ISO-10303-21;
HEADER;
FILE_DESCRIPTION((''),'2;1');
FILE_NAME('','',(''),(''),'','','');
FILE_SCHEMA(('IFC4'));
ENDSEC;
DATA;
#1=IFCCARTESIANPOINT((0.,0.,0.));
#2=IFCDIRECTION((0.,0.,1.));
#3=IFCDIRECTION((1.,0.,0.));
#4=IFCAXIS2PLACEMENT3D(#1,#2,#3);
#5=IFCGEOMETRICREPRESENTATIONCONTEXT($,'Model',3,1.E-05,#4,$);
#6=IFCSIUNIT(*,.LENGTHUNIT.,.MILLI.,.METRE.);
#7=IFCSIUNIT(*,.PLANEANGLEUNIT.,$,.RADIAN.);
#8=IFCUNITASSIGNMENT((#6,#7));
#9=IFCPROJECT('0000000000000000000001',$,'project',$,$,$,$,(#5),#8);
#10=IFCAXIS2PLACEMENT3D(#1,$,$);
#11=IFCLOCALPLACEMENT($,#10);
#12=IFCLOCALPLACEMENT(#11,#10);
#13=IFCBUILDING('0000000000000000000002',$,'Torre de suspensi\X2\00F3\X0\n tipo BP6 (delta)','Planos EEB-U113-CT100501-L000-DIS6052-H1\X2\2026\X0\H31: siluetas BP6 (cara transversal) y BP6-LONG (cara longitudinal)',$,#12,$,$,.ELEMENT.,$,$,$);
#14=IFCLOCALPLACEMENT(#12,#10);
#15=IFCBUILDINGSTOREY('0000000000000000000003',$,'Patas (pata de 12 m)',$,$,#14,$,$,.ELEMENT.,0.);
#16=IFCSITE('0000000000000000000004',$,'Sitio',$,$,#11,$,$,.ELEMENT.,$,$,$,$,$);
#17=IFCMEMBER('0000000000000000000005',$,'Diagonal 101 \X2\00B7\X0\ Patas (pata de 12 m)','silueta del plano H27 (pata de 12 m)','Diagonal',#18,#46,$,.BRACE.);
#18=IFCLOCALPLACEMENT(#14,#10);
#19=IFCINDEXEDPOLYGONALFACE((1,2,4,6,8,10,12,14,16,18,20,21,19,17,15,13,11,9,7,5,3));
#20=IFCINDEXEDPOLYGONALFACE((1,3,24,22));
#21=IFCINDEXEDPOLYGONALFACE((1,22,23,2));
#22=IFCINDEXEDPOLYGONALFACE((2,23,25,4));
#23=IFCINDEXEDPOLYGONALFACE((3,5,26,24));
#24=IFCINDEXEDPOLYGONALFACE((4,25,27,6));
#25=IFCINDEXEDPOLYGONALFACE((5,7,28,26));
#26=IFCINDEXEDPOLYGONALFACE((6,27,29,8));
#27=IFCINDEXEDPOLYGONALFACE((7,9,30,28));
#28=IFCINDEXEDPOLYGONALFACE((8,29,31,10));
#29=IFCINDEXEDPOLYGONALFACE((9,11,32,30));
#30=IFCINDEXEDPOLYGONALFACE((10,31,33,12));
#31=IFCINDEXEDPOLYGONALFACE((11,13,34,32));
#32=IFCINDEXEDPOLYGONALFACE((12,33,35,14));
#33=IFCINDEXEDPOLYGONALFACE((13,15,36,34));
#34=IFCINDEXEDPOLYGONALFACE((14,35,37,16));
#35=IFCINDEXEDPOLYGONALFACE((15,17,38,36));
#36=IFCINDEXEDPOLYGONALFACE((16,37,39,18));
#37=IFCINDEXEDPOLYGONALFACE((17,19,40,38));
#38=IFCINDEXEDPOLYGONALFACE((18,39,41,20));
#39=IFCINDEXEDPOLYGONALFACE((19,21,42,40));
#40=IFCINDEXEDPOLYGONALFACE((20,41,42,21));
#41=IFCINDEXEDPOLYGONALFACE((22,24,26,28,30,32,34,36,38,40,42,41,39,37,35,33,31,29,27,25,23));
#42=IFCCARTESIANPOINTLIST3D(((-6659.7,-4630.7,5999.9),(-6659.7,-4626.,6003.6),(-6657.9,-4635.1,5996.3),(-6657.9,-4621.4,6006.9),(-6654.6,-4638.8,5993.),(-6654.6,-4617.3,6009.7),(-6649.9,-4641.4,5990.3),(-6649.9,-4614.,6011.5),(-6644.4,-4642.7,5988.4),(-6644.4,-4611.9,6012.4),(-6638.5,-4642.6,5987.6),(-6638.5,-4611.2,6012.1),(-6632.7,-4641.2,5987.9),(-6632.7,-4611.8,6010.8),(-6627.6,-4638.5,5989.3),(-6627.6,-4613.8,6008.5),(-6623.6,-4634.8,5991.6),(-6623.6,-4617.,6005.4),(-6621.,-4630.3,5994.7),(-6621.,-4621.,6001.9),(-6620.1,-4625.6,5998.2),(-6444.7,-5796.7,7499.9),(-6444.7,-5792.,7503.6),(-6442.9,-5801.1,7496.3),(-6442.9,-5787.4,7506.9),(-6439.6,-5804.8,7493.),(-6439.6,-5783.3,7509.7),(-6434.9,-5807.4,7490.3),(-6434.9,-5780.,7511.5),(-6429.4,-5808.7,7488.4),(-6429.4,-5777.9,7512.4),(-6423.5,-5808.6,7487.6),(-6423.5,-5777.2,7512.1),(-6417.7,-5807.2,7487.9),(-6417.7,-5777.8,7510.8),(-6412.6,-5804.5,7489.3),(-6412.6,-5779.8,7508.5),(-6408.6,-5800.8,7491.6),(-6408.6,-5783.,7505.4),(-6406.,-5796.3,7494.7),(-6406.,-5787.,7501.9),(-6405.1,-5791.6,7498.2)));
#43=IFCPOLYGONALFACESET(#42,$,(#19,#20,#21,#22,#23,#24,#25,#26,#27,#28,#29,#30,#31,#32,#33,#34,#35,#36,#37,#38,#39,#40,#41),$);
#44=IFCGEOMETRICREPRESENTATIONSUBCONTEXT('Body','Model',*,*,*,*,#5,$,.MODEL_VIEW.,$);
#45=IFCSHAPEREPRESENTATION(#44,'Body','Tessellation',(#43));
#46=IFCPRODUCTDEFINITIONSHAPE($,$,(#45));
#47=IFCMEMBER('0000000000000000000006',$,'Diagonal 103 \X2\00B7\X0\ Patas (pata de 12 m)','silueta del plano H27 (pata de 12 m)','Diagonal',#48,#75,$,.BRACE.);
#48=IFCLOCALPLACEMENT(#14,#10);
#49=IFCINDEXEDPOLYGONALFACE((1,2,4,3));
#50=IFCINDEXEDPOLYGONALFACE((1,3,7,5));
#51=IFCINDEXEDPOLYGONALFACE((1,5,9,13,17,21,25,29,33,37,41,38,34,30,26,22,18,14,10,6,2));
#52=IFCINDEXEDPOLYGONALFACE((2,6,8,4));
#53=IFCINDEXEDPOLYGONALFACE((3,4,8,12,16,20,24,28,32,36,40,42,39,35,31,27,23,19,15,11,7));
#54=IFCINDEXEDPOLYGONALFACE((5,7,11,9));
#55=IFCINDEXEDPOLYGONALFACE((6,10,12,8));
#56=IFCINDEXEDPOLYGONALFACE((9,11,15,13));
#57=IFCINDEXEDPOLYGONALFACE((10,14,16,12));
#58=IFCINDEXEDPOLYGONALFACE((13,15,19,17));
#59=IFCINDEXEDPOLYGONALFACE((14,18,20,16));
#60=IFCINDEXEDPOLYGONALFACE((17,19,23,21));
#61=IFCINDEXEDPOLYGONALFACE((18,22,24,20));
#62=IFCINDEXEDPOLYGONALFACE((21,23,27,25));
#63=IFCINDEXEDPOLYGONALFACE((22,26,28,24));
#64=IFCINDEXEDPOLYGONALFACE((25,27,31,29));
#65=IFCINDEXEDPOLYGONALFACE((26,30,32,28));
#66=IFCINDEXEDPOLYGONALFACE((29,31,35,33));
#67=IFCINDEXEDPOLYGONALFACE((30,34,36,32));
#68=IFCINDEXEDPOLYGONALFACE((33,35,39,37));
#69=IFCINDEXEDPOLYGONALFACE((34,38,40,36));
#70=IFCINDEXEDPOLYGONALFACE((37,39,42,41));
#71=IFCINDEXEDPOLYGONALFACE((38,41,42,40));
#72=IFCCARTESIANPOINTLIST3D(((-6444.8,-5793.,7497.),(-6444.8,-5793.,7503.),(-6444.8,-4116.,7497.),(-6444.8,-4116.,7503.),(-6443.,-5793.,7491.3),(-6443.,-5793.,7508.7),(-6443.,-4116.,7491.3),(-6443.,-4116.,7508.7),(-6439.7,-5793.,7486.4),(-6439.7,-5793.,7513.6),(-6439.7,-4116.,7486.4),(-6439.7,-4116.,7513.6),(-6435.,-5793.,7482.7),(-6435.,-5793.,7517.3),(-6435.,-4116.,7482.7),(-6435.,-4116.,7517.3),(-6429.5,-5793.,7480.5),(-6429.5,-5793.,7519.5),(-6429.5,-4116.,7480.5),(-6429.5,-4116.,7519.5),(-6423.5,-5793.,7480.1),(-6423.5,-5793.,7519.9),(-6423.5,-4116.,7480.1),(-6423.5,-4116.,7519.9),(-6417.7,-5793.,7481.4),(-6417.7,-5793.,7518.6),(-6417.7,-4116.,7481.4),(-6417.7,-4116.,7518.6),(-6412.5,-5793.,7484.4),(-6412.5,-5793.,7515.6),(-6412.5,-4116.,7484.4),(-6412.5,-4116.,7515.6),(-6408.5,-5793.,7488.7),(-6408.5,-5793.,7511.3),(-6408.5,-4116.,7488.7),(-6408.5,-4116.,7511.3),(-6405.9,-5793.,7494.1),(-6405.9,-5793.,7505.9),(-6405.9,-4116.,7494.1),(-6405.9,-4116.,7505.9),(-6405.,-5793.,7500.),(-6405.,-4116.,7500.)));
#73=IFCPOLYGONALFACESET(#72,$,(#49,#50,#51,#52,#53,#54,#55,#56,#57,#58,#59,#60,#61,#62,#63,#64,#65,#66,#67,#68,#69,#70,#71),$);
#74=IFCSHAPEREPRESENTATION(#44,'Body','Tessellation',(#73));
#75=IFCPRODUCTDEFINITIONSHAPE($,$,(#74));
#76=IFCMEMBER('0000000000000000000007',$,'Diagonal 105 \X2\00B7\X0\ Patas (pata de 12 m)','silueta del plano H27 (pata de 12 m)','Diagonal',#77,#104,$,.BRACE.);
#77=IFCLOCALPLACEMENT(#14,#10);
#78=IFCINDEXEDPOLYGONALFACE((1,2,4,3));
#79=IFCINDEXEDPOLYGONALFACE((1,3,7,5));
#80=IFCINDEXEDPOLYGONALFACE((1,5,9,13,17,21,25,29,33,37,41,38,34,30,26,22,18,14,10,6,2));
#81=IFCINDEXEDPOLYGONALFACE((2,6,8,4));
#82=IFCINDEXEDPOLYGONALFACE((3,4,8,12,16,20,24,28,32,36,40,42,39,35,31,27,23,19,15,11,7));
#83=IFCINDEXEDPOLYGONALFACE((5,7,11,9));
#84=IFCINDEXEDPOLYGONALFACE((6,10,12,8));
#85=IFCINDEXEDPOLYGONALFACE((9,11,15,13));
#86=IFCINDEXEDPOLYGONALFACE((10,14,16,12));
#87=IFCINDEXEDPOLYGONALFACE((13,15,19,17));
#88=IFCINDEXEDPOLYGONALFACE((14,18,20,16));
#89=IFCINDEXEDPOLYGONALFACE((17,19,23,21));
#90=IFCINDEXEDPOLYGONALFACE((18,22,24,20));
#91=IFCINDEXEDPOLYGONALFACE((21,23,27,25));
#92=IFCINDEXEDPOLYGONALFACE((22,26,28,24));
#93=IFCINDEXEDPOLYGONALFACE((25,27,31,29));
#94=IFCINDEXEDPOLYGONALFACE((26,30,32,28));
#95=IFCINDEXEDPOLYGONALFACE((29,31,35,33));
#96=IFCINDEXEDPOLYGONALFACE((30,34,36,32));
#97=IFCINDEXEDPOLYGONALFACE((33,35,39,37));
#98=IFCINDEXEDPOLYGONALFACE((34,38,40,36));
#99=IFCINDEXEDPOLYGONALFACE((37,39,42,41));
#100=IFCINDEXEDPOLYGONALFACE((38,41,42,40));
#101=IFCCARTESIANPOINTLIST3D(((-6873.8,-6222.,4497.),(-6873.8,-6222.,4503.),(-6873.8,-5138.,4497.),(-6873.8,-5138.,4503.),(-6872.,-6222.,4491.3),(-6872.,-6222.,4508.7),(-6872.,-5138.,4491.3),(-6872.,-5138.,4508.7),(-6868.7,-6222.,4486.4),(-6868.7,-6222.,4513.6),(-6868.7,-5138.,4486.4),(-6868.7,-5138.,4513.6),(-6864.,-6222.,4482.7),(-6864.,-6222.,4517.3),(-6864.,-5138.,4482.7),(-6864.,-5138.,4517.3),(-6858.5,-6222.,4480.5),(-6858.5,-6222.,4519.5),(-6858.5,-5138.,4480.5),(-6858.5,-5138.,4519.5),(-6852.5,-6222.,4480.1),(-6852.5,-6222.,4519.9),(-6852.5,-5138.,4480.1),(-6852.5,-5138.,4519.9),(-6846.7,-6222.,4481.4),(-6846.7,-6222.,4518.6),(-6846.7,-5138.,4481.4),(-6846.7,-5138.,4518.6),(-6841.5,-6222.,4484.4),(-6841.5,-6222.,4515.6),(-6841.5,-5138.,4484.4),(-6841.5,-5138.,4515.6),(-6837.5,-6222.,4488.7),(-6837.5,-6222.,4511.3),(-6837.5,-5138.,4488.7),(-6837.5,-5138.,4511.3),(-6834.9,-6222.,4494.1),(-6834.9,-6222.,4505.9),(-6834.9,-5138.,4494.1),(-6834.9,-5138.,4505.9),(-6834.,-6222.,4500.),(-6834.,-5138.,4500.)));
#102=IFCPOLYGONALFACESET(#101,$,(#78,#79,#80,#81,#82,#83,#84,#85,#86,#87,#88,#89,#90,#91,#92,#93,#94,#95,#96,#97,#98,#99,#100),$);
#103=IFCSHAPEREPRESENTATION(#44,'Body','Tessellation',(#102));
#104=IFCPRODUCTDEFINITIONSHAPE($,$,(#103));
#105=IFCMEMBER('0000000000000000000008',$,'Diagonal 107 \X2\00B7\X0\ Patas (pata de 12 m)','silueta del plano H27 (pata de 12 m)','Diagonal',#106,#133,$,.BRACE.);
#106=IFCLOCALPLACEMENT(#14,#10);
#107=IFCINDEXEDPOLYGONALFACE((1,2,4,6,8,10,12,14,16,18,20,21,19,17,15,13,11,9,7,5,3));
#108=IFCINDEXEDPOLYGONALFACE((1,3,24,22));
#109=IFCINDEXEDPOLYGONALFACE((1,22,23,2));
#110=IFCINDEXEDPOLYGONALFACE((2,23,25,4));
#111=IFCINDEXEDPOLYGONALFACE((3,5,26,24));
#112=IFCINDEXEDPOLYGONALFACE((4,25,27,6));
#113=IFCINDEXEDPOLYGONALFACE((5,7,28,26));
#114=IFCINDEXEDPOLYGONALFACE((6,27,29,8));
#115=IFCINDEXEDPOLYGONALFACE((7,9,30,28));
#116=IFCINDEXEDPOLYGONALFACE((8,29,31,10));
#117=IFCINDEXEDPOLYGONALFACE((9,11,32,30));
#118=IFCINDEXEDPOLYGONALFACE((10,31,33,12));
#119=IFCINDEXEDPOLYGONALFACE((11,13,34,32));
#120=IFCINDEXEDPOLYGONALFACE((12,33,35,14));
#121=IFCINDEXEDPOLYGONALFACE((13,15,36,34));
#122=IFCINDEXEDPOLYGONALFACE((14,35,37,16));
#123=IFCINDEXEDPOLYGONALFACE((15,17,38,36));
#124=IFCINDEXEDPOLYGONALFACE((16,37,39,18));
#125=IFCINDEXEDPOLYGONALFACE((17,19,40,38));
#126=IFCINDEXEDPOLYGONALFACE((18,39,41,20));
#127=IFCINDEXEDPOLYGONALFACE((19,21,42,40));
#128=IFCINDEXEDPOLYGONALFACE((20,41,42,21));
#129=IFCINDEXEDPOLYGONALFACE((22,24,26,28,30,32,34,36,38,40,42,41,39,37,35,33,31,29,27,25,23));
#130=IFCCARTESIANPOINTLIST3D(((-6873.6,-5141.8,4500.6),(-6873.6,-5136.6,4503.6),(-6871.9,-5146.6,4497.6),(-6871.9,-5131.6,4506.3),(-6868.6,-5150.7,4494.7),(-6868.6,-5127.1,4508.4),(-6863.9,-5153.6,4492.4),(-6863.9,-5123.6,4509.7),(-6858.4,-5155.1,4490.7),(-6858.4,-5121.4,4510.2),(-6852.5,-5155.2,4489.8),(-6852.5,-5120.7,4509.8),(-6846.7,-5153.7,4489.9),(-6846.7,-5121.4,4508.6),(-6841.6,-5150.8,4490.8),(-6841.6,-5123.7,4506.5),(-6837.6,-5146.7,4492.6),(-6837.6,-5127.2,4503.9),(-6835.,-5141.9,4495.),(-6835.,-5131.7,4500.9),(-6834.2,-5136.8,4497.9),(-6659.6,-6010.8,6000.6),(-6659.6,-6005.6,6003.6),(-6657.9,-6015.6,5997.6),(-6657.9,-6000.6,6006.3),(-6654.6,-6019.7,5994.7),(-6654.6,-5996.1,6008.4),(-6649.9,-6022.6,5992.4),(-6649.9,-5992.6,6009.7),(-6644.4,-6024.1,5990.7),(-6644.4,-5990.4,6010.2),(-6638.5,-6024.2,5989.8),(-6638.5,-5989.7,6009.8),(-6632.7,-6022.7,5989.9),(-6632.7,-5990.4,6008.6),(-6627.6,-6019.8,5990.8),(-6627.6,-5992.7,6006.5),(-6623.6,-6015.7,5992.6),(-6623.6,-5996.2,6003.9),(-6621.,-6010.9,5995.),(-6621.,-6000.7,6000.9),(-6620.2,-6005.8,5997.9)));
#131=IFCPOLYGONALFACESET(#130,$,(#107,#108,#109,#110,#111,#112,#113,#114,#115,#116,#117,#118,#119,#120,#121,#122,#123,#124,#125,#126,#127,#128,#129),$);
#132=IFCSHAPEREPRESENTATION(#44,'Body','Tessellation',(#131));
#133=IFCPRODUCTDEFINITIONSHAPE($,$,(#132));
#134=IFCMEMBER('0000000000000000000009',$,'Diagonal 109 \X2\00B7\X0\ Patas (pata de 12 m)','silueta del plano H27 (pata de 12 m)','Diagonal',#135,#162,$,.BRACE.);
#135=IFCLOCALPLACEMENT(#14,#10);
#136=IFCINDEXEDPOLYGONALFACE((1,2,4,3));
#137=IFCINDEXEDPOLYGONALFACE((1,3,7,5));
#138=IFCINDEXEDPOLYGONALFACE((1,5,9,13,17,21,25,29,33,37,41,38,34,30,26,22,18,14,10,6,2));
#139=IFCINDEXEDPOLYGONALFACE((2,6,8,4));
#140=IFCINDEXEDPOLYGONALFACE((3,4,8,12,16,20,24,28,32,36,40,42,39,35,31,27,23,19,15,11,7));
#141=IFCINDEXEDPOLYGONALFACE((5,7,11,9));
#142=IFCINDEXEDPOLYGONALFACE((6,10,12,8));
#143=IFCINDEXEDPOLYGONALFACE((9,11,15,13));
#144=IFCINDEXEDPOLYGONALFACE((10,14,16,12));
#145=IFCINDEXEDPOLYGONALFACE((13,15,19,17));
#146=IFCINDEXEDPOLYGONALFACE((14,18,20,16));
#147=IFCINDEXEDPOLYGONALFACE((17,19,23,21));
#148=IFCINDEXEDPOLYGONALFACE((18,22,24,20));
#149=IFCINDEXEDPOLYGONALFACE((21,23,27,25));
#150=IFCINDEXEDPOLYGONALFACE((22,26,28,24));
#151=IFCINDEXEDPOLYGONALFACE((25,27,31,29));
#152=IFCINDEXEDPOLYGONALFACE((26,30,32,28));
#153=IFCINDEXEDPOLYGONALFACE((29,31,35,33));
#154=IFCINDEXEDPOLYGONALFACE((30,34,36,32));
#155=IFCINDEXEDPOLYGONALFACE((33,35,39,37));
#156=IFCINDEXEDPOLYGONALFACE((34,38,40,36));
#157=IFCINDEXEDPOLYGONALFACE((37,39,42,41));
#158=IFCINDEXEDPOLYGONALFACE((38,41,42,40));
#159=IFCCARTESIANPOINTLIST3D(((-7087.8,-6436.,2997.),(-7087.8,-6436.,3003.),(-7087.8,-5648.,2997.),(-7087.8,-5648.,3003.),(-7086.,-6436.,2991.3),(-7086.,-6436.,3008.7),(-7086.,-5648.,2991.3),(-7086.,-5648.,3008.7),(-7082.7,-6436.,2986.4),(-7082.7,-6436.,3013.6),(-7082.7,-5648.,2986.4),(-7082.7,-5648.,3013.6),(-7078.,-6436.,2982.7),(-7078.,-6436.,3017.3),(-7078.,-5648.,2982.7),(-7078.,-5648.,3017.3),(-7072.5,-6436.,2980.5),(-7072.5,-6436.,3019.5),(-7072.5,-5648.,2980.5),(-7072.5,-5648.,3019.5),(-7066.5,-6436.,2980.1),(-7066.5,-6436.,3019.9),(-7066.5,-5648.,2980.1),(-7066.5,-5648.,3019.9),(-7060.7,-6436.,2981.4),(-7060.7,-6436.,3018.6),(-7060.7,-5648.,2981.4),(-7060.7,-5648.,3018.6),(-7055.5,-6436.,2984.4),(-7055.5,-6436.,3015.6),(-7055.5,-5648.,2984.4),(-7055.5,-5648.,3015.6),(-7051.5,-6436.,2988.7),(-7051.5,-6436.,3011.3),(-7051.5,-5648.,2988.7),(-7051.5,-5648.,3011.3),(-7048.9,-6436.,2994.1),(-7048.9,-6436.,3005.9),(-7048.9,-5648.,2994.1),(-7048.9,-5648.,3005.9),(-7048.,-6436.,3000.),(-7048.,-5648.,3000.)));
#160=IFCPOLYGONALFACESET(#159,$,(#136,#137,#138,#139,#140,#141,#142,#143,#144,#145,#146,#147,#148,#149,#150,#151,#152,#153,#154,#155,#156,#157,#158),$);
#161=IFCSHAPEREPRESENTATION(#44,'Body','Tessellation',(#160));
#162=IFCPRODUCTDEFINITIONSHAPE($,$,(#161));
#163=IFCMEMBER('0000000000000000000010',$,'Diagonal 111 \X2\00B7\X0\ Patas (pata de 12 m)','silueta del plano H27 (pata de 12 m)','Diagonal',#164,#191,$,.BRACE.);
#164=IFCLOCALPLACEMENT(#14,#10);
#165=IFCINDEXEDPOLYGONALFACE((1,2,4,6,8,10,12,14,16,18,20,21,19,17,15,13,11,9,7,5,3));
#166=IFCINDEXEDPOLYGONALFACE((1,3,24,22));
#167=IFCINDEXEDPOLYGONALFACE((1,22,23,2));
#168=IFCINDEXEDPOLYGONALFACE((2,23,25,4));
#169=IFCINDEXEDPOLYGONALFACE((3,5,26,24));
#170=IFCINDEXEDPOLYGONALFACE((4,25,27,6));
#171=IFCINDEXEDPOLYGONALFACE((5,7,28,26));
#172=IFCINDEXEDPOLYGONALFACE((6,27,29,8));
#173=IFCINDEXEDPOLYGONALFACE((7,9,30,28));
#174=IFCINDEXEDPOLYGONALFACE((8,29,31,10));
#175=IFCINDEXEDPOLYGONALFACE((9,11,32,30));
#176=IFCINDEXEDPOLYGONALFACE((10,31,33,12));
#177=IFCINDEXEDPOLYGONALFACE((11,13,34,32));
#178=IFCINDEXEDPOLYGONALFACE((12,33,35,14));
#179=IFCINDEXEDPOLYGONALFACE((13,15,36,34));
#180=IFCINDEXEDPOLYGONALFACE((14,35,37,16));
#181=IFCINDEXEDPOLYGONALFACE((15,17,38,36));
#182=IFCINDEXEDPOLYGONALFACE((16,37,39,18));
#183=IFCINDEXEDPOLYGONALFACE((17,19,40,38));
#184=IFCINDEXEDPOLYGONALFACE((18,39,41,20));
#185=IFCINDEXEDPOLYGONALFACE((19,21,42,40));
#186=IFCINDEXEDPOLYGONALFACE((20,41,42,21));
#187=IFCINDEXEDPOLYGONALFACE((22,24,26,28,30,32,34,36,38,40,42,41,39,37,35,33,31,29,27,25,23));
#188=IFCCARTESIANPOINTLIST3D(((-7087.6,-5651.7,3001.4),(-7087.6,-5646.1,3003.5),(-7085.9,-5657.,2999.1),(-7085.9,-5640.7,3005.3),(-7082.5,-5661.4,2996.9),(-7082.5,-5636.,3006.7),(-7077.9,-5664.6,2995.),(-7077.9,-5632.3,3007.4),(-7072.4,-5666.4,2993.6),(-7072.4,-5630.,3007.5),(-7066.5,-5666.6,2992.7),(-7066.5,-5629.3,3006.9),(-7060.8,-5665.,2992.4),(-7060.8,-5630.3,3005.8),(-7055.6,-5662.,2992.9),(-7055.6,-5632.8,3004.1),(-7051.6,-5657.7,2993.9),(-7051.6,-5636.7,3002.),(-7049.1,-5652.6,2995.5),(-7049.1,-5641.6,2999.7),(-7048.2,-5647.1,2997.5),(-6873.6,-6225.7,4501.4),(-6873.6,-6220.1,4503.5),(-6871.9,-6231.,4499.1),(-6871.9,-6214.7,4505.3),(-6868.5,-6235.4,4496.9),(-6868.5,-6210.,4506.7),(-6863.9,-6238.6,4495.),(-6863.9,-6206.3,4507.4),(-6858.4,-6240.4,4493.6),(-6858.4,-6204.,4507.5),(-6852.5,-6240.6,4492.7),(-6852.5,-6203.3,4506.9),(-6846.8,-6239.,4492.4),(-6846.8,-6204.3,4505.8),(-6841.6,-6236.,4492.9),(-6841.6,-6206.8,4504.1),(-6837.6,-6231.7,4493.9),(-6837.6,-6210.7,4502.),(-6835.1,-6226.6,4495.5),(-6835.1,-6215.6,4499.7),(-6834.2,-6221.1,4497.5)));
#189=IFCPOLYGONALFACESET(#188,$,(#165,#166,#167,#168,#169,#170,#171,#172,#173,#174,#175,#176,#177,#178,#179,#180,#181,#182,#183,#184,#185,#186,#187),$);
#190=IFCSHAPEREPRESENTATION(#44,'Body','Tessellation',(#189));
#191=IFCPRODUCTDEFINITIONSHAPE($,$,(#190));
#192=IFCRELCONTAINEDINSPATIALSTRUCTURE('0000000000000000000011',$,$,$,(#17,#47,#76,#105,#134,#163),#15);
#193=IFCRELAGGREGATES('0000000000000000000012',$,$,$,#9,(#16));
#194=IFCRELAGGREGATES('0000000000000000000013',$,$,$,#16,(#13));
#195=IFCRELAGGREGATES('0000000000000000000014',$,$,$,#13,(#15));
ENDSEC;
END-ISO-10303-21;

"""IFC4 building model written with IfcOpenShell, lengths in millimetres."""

from ifc_helpers import new_model, si_unit, frame, origin, origin_with_axes, place, context, subcontext, project, spatial, circle, extrude, element, save


model = new_model("IFC4")

# Units and contexts
model_context = context("Model", 3, precision=1e-05, world=origin_with_axes())
body_context = subcontext(model_context, "Body", "Model", "MODEL_VIEW")
ifc_project = project(units=[si_unit("LENGTHUNIT", "METRE", prefix="MILLI"), si_unit("PLANEANGLEUNIT", "RADIAN")], contexts=[model_context])

# Site, building, storey
site_placement = place(None, origin())
site = spatial("IfcSite", under=ifc_project, at=site_placement, Name="Sitio", CompositionType="ELEMENT")
building_placement = place(site_placement, origin())
building = spatial("IfcBuilding", under=site, at=building_placement, Name="Torre de suspensión tipo BP6 (delta)", Description="Planos EEB-U113-CT100501-L000-DIS6052-H1…H31: siluetas BP6 (cara transversal) y BP6-LONG (cara longitudinal)", CompositionType="ELEMENT")
storey_placement = place(building_placement, origin())
storey = spatial("IfcBuildingStorey", under=building, at=storey_placement, Name="Patas (pata de 12 m)", CompositionType="ELEMENT", Elevation=0.0)

# Members
member_1_placement = place(storey_placement, frame((-6640.0, -4627.0, 6000.0), z_axis=(0.112447, -0.60983, 0.784515), x_axis=(0.993658, 0.069011, -0.08878)))
element("IfcMember", 1, at=member_1_placement, inside=storey, Name="Diagonal 101 · Patas (pata de 12 m)", Description="silueta del plano H27 (pata de 12 m)", ObjectType="Diagonal", PredefinedType="BRACE", context=body_context, shape_type="SweptSolid", body=[
    extrude(circle(Radius=20.0), None, (0.0, 0.0, 1.0), 1912.0),
])
member_2_placement = place(storey_placement, frame((-6425.0, -5793.0, 7500.0), z_axis=(0.0, 1.0, 0.0), x_axis=(1.0, 0.0, 0.0)))
element("IfcMember", 2, at=member_2_placement, inside=storey, Name="Diagonal 103 · Patas (pata de 12 m)", Description="silueta del plano H27 (pata de 12 m)", ObjectType="Diagonal", PredefinedType="BRACE", context=body_context, shape_type="SweptSolid", body=[
    extrude(circle(Radius=20.0), None, (0.0, 0.0, 1.0), 1677.0),
])
member_3_placement = place(storey_placement, frame((-6854.0, -6222.0, 4500.0), z_axis=(0.0, 1.0, 0.0), x_axis=(1.0, 0.0, 0.0)))
element("IfcMember", 3, at=member_3_placement, inside=storey, Name="Diagonal 105 · Patas (pata de 12 m)", Description="silueta del plano H27 (pata de 12 m)", ObjectType="Diagonal", PredefinedType="BRACE", context=body_context, shape_type="SweptSolid", body=[
    extrude(circle(Radius=20.0), None, (0.0, 0.0, 1.0), 1084.0),
])
member_4_placement = place(storey_placement, frame((-6854.0, -5138.0, 4500.0), z_axis=(0.122517, -0.49751, 0.858763), x_axis=(0.992466, 0.061416, -0.106012)))
element("IfcMember", 4, at=member_4_placement, inside=storey, Name="Diagonal 107 · Patas (pata de 12 m)", Description="silueta del plano H27 (pata de 12 m)", ObjectType="Diagonal", PredefinedType="BRACE", context=body_context, shape_type="SweptSolid", body=[
    extrude(circle(Radius=20.0), None, (0.0, 0.0, 1.0), 1746.7),
])
member_5_placement = place(storey_placement, frame((-7068.0, -6436.0, 3000.0), z_axis=(0.0, 1.0, 0.0), x_axis=(1.0, 0.0, 0.0)))
element("IfcMember", 5, at=member_5_placement, inside=storey, Name="Diagonal 109 · Patas (pata de 12 m)", Description="silueta del plano H27 (pata de 12 m)", ObjectType="Diagonal", PredefinedType="BRACE", context=body_context, shape_type="SweptSolid", body=[
    extrude(circle(Radius=20.0), None, (0.0, 0.0, 1.0), 788.0),
])
member_6_placement = place(storey_placement, frame((-7068.0, -5648.0, 3000.0), z_axis=(0.132077, -0.354262, 0.925772), x_axis=(0.991239, 0.047203, -0.123354)))
element("IfcMember", 6, at=member_6_placement, inside=storey, Name="Diagonal 111 · Patas (pata de 12 m)", Description="silueta del plano H27 (pata de 12 m)", ObjectType="Diagonal", PredefinedType="BRACE", context=body_context, shape_type="SweptSolid", body=[
    extrude(circle(Radius=20.0), None, (0.0, 0.0, 1.0), 1620.3),
])

save(model, "model.ifc")
